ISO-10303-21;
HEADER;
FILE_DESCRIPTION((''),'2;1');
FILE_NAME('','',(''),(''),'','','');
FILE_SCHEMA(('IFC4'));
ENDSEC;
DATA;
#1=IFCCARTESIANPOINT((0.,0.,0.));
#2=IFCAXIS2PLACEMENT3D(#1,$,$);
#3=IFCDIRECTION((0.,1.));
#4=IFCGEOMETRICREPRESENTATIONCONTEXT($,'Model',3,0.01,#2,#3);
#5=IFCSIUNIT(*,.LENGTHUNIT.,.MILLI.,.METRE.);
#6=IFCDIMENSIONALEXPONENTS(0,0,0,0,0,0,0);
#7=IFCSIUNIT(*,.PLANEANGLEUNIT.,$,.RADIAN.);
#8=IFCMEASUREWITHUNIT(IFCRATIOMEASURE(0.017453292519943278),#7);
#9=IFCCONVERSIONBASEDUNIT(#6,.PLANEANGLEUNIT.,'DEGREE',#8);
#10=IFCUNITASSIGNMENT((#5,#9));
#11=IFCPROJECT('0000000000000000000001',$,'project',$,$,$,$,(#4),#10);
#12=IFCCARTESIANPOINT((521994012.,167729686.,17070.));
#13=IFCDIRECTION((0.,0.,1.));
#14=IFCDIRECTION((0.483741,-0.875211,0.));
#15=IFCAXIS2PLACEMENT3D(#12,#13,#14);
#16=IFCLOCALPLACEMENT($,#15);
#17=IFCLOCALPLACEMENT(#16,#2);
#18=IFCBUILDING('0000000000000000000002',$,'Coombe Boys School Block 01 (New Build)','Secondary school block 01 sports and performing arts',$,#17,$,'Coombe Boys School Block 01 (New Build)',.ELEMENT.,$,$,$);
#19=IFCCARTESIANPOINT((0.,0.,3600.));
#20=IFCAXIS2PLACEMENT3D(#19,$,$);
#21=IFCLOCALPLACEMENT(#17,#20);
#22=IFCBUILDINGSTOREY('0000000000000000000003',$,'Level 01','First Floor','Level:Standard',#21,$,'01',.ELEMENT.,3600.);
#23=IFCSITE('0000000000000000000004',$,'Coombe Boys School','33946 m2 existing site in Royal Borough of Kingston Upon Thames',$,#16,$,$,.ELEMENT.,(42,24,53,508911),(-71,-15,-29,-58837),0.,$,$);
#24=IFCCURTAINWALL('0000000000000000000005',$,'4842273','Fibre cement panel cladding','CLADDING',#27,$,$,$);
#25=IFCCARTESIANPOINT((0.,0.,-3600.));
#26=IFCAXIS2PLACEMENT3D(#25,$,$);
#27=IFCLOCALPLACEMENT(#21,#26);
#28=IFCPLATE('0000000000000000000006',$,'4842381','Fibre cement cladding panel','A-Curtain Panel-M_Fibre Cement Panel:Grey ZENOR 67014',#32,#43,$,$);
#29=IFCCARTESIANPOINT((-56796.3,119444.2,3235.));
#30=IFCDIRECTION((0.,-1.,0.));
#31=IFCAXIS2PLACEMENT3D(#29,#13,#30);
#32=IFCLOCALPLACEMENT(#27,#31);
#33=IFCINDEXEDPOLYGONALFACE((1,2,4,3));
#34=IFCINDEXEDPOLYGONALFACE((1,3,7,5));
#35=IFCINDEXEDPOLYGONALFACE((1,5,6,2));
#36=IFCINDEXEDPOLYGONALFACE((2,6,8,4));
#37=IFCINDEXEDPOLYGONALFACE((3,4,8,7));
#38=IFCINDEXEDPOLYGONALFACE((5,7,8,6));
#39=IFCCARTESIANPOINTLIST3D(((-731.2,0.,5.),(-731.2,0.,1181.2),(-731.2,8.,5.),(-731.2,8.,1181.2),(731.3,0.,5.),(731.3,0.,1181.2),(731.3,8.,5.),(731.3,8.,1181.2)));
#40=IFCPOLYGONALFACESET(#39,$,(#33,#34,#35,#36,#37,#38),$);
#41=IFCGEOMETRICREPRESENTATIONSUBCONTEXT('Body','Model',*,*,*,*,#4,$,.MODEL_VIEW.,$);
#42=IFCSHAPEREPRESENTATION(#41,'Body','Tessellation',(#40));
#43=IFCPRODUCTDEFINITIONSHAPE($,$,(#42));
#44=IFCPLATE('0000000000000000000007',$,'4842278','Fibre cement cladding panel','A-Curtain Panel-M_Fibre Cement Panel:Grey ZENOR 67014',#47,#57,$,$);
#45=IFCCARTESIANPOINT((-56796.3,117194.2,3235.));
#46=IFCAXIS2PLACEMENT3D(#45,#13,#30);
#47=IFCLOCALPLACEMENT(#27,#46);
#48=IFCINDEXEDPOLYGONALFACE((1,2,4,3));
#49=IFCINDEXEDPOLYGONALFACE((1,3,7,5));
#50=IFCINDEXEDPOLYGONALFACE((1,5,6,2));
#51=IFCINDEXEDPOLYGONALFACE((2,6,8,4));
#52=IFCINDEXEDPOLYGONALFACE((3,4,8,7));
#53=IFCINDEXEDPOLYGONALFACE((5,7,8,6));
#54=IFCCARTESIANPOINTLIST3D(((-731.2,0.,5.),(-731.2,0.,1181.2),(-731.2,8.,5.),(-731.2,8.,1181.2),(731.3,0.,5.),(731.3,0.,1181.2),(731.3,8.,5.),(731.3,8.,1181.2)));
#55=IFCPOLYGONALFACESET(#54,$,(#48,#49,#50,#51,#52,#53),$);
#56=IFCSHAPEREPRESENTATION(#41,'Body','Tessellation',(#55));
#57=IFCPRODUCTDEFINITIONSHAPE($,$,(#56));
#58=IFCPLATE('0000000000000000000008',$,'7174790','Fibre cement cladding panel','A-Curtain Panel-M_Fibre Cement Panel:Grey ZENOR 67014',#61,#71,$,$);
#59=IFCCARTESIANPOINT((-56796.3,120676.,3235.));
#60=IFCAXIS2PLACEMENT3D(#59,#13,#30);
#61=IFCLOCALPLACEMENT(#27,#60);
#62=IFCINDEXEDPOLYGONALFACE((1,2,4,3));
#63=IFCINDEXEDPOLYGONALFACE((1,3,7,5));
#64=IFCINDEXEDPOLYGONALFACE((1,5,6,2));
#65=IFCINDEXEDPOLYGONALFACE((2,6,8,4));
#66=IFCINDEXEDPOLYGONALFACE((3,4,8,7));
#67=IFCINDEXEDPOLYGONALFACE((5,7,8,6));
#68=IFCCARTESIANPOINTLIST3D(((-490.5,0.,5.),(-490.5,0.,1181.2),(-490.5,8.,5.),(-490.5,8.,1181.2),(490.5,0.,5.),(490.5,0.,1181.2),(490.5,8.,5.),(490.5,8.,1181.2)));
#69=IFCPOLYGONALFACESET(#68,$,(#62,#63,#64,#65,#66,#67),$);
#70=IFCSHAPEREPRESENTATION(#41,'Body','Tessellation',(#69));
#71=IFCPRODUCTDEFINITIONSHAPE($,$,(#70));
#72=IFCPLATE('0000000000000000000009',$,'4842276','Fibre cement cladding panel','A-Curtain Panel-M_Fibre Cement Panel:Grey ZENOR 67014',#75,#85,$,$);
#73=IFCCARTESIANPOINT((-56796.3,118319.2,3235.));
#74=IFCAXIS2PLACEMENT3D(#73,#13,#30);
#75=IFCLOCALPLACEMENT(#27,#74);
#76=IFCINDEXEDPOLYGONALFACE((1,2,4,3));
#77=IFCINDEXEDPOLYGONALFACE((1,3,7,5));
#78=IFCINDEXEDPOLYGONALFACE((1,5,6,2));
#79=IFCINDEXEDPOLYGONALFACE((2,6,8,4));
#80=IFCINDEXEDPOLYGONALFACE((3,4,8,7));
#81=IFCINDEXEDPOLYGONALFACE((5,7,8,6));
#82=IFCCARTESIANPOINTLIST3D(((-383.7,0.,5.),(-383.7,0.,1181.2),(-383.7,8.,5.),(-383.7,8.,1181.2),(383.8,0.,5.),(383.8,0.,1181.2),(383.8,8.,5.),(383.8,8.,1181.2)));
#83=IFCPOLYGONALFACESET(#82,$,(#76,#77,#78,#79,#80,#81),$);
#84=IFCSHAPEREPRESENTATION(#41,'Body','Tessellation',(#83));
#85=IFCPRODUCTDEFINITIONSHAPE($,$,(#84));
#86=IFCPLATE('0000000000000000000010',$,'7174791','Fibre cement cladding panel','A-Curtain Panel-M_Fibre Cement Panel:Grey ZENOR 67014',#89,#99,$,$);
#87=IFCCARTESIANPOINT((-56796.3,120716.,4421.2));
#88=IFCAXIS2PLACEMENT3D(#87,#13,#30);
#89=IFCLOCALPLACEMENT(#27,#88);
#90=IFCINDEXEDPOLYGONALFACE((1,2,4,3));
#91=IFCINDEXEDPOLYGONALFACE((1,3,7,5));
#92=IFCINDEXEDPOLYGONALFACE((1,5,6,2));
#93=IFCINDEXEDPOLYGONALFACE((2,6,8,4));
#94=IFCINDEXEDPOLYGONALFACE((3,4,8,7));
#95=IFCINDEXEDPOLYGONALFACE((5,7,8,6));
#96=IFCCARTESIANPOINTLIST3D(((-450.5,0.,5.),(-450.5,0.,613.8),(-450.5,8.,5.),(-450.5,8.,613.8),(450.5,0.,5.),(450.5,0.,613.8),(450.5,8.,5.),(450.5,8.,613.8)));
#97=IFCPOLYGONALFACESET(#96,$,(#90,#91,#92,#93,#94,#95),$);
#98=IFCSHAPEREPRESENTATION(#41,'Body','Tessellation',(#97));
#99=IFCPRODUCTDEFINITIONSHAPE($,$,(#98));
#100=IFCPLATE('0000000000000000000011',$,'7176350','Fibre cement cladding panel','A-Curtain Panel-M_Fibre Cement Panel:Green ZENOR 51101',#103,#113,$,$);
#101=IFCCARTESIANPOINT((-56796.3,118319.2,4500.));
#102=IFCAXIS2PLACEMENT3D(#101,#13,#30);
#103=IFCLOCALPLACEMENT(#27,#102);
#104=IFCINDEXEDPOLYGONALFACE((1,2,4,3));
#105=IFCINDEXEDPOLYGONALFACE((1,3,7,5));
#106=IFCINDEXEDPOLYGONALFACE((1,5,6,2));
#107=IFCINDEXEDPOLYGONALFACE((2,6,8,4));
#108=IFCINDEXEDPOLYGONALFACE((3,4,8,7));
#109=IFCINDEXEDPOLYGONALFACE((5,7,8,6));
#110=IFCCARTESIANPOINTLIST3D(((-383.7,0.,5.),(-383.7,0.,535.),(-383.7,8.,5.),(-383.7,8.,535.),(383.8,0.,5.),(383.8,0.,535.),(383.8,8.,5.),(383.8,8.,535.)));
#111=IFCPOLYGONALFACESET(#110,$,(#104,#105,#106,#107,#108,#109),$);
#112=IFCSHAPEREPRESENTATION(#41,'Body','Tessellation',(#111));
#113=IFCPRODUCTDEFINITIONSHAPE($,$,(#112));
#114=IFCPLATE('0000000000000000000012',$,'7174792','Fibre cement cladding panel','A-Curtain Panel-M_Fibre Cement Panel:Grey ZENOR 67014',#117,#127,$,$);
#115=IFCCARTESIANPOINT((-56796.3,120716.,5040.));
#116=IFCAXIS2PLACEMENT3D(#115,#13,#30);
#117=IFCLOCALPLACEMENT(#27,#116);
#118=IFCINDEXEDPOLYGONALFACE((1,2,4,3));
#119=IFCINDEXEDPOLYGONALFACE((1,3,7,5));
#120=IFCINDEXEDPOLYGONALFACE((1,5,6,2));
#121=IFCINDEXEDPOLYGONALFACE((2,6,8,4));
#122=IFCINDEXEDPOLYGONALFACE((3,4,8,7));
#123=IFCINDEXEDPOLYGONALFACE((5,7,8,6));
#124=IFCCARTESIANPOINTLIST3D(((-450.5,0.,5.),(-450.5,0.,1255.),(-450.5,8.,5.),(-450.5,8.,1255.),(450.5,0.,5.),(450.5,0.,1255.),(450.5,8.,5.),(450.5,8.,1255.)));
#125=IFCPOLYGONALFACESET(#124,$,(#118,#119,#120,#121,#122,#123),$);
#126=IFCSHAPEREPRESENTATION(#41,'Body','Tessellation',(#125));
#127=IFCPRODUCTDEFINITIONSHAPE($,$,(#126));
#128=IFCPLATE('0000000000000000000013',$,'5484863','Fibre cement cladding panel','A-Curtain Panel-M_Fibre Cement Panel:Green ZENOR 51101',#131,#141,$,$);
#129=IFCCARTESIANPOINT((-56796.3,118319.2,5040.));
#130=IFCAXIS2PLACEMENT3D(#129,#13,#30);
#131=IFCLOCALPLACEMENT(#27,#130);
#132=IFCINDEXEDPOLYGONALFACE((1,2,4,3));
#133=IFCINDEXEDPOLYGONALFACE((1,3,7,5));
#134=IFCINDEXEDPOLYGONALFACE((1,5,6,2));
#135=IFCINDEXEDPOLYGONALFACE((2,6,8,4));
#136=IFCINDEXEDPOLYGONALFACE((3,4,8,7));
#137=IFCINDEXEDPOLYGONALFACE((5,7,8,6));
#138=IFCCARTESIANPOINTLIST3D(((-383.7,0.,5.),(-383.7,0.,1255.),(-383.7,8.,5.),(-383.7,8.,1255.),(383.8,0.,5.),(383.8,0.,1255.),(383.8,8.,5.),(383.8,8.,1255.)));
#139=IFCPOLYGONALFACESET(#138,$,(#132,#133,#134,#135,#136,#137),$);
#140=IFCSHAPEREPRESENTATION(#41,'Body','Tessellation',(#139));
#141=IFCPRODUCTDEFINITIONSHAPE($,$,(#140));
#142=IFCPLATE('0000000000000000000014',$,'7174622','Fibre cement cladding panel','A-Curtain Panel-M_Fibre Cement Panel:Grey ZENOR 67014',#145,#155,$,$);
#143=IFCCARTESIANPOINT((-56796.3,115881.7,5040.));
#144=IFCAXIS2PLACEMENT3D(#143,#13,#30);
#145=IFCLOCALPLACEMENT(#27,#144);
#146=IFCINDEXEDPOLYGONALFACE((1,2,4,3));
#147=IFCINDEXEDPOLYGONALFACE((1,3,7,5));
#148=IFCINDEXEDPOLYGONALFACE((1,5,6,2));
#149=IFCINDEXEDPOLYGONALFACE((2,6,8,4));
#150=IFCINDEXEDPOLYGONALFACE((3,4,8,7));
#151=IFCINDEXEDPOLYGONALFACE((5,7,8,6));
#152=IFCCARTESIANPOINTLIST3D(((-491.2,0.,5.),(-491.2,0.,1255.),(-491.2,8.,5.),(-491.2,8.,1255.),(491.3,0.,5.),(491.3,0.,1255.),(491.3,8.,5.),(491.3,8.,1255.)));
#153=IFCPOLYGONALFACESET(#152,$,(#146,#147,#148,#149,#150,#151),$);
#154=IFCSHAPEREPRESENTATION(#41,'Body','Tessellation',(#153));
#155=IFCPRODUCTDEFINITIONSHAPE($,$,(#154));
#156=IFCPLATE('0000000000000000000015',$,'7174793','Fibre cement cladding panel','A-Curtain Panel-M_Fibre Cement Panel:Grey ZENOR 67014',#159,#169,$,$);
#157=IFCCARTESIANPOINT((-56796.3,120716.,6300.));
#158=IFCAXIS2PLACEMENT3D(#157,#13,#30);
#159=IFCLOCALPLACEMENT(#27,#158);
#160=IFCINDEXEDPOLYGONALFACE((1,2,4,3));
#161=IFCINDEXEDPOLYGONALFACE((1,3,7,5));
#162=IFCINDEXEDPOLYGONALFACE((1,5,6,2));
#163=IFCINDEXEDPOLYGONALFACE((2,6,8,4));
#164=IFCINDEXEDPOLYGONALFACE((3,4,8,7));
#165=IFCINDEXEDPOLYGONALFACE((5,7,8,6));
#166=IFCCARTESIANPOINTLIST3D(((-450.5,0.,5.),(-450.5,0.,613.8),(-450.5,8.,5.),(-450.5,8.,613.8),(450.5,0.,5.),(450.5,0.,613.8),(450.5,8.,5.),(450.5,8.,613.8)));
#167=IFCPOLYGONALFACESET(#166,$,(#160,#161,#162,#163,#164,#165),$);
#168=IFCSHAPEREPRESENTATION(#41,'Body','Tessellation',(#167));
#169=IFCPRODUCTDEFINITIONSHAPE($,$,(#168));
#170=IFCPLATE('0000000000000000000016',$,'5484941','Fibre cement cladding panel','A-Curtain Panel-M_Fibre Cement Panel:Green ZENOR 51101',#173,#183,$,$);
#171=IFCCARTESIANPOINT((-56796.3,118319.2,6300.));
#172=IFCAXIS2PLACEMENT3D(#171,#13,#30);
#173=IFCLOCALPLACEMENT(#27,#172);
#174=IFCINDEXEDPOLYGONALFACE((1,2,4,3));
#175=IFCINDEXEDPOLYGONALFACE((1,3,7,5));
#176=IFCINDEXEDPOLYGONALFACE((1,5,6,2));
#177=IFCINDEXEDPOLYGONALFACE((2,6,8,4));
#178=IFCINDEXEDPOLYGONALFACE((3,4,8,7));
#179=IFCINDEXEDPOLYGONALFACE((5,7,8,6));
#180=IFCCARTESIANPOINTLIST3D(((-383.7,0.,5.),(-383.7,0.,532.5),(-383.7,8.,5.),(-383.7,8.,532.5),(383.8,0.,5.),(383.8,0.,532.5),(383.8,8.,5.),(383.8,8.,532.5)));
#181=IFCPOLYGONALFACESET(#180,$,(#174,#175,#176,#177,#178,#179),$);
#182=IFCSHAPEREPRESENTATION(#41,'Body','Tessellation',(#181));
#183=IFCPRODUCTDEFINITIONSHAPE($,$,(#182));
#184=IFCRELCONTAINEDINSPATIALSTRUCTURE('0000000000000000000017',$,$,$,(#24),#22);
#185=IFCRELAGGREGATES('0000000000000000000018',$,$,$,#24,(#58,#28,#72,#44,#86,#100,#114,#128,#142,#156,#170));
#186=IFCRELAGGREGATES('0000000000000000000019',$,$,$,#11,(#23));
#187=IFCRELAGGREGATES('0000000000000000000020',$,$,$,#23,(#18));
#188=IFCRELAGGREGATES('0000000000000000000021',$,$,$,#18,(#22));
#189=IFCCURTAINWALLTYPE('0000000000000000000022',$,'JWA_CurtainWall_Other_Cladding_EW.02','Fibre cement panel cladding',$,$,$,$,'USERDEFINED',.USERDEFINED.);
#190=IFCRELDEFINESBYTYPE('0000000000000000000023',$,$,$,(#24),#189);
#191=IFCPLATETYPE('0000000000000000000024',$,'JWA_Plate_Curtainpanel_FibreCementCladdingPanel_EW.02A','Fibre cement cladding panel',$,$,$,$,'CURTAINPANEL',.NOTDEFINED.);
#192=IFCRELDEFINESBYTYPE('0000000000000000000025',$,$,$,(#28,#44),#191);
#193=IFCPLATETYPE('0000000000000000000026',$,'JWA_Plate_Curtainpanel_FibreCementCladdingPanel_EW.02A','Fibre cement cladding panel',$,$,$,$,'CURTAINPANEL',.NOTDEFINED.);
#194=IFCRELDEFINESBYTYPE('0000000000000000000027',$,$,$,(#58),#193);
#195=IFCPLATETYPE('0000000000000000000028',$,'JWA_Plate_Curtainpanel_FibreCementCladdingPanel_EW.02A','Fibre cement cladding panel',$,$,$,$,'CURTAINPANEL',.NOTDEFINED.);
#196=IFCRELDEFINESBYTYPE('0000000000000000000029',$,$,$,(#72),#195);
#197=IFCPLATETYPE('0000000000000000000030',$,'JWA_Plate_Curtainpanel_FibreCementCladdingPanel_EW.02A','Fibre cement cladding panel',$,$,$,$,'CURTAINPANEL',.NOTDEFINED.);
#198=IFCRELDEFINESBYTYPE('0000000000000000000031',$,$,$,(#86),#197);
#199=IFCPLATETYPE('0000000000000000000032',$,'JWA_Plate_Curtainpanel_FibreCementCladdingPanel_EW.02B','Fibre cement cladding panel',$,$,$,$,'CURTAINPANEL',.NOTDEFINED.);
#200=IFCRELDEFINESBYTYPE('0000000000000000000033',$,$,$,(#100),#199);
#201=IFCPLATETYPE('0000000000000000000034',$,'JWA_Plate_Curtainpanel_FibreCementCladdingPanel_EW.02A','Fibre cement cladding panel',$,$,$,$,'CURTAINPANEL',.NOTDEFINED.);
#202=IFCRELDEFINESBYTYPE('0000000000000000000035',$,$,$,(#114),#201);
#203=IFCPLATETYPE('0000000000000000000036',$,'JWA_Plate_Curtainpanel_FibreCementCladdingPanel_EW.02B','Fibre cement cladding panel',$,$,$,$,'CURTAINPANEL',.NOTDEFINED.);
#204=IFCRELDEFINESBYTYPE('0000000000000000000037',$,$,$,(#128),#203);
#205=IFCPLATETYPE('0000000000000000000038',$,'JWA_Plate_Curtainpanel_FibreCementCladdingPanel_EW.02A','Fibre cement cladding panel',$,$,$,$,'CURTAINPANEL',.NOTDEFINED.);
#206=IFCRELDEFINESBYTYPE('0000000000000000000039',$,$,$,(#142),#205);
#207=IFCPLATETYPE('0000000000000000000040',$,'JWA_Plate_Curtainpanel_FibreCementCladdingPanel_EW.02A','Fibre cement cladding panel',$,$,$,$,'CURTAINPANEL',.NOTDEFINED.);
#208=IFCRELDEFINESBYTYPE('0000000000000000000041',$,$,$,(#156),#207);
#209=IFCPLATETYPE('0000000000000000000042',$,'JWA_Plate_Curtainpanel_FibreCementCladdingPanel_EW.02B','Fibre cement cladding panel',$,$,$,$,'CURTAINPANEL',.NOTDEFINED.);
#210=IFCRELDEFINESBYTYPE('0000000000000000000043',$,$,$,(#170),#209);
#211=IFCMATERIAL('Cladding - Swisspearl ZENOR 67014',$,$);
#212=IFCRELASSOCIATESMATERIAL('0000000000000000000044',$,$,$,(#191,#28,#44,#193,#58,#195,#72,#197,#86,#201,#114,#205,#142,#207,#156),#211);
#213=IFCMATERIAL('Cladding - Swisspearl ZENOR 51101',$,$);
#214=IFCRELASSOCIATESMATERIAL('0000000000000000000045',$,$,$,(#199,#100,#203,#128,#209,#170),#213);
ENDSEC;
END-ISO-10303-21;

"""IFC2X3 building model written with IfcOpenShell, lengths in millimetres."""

from ifc_helpers import new_model, entity, si_unit, converted_unit, direction, frame, origin, origin_2d_with_axis, place, context, subcontext, project, spatial, rectangle, extrude, source, transform, mapped, material, type_object, type_shapes, element, aggregate, save


model = new_model("IFC2X3")

# Units and contexts
model_context = context("Model", 3, precision=0.01, world=origin(), true_north=direction((0.0, 1.0)))
body_context = subcontext(model_context, "Body", "Model", "MODEL_VIEW")
ifc_project = project(units=[si_unit("LENGTHUNIT", "METRE", prefix="MILLI"), converted_unit("PLANEANGLEUNIT", "DEGREE", entity("IfcRatioMeasure", 0.017453292519943278), si_unit("PLANEANGLEUNIT", "RADIAN"), dimensions=[0, 0, 0, 0, 0, 0, 0])], contexts=[model_context])

# Site, building, storey
site_placement = place(None, frame((521994012.0, 167729686.0, 17070.0), z_axis=(0.0, 0.0, 1.0), x_axis=(0.483741, -0.875211, 0.0)))
site = spatial("IfcSite", under=ifc_project, at=site_placement, Name="Coombe Boys School", Description="33946 m2 existing site in Royal Borough of Kingston Upon Thames", CompositionType="ELEMENT", RefLatitude=(42, 24, 53, 508911), RefLongitude=(-71, -15, -29, -58837), RefElevation=0.0)
building_placement = place(site_placement, origin())
building = spatial("IfcBuilding", under=site, at=building_placement, Name="Coombe Boys School Block 01 (New Build)", Description="Secondary school block 01 sports and performing arts", LongName="Coombe Boys School Block 01 (New Build)", CompositionType="ELEMENT")
storey_placement = place(building_placement, frame((0.0, 0.0, 3600.0)))
storey = spatial("IfcBuildingStorey", under=building, at=storey_placement, Name="Level 01", Description="First Floor", ObjectType="Level:Standard", LongName="01", CompositionType="ELEMENT", Elevation=3600.0)

# Curtain wall, plates
curtain_wall_type = type_object("IfcCurtainWallType", Name="JWA_CurtainWall_Other_Cladding_EW.02", Description="Fibre cement panel cladding", ElementType="USERDEFINED", PredefinedType="USERDEFINED")
curtain_wall_placement = place(storey_placement, frame((0.0, 0.0, -3600.0)))
curtain_wall = element("IfcCurtainWall", 1, at=curtain_wall_placement, inside=storey, type_object=curtain_wall_type, Name="4842273", Description="Fibre cement panel cladding", ObjectType="CLADDING")
ifc_material_1 = material(Name="Cladding - Swisspearl ZENOR 67014")
plate_type_1 = type_object("IfcPlateType", Name="JWA_Plate_Curtainpanel_FibreCementCladdingPanel_EW.02A", Description="Fibre cement cladding panel", ElementType="CURTAINPANEL", PredefinedType="NOTDEFINED", material=ifc_material_1)
shared_shape_1 = source(origin(), body_context, "Body", "SweptSolid", [
    extrude(rectangle(XDim=8.0, YDim=1462.5, at=origin_2d_with_axis()), frame((0.0, 4.0, 5.0), z_axis=(0.0, 0.0, 1.0), x_axis=(0.0, 1.0, 0.0)), (0.0, 0.0, 1.0), 1176.3),
])
type_shapes(plate_type_1, [shared_shape_1])
plate_1_placement = place(curtain_wall_placement, frame((-56796.3, 119444.2, 3235.0), z_axis=(0.0, 0.0, 1.0), x_axis=(0.0, -1.0, 0.0)))
plate_1 = element("IfcPlate", 2, at=plate_1_placement, type_object=plate_type_1, material=ifc_material_1, Name="4842381", Description="Fibre cement cladding panel", ObjectType="A-Curtain Panel-M_Fibre Cement Panel:Grey ZENOR 67014", context=body_context, shape_type="MappedRepresentation", body=[
    mapped(shared_shape_1, transform((0.0, 0.0, 0.0), scale=1.0)),
])
plate_2_placement = place(curtain_wall_placement, frame((-56796.3, 117194.2, 3235.0), z_axis=(0.0, 0.0, 1.0), x_axis=(0.0, -1.0, 0.0)))
plate_2 = element("IfcPlate", 3, at=plate_2_placement, type_object=plate_type_1, material=ifc_material_1, Name="4842278", Description="Fibre cement cladding panel", ObjectType="A-Curtain Panel-M_Fibre Cement Panel:Grey ZENOR 67014", context=body_context, shape_type="MappedRepresentation", body=[
    mapped(shared_shape_1, transform((0.0, 0.0, 0.0), scale=1.0)),
])
plate_type_2 = type_object("IfcPlateType", Name="JWA_Plate_Curtainpanel_FibreCementCladdingPanel_EW.02A", Description="Fibre cement cladding panel", ElementType="CURTAINPANEL", PredefinedType="NOTDEFINED", material=ifc_material_1)
shared_shape_2 = source(origin(), body_context, "Body", "SweptSolid", [
    extrude(rectangle(XDim=8.0, YDim=981.0, at=origin_2d_with_axis()), frame((0.0, 4.0, 5.0), z_axis=(0.0, 0.0, 1.0), x_axis=(0.0, 1.0, 0.0)), (0.0, 0.0, 1.0), 1176.2),
])
type_shapes(plate_type_2, [shared_shape_2])
plate_3_placement = place(curtain_wall_placement, frame((-56796.3, 120676.0, 3235.0), z_axis=(0.0, 0.0, 1.0), x_axis=(0.0, -1.0, 0.0)))
plate_3 = element("IfcPlate", 4, at=plate_3_placement, type_object=plate_type_2, material=ifc_material_1, Name="7174790", Description="Fibre cement cladding panel", ObjectType="A-Curtain Panel-M_Fibre Cement Panel:Grey ZENOR 67014", context=body_context, shape_type="MappedRepresentation", body=[
    mapped(shared_shape_2, transform((0.0, 0.0, 0.0), scale=1.0)),
])
plate_type_3 = type_object("IfcPlateType", Name="JWA_Plate_Curtainpanel_FibreCementCladdingPanel_EW.02A", Description="Fibre cement cladding panel", ElementType="CURTAINPANEL", PredefinedType="NOTDEFINED", material=ifc_material_1)
shared_shape_3 = source(origin(), body_context, "Body", "SweptSolid", [
    extrude(rectangle(XDim=8.0, YDim=767.5, at=origin_2d_with_axis()), frame((0.0, 4.0, 5.0), z_axis=(0.0, 0.0, 1.0), x_axis=(0.0, 1.0, 0.0)), (0.0, 0.0, 1.0), 1176.2),
])
type_shapes(plate_type_3, [shared_shape_3])
plate_4_placement = place(curtain_wall_placement, frame((-56796.3, 118319.2, 3235.0), z_axis=(0.0, 0.0, 1.0), x_axis=(0.0, -1.0, 0.0)))
plate_4 = element("IfcPlate", 5, at=plate_4_placement, type_object=plate_type_3, material=ifc_material_1, Name="4842276", Description="Fibre cement cladding panel", ObjectType="A-Curtain Panel-M_Fibre Cement Panel:Grey ZENOR 67014", context=body_context, shape_type="MappedRepresentation", body=[
    mapped(shared_shape_3, transform((0.0, 0.0, 0.0), scale=1.0)),
])
plate_type_4 = type_object("IfcPlateType", Name="JWA_Plate_Curtainpanel_FibreCementCladdingPanel_EW.02A", Description="Fibre cement cladding panel", ElementType="CURTAINPANEL", PredefinedType="NOTDEFINED", material=ifc_material_1)
shared_shape_4 = source(origin(), body_context, "Body", "SweptSolid", [
    extrude(rectangle(XDim=8.0, YDim=901.0, at=origin_2d_with_axis()), frame((0.0, 4.0, 5.0), z_axis=(0.0, 0.0, 1.0), x_axis=(0.0, 1.0, 0.0)), (0.0, 0.0, 1.0), 608.8),
])
type_shapes(plate_type_4, [shared_shape_4])
plate_5_placement = place(curtain_wall_placement, frame((-56796.3, 120716.0, 4421.2), z_axis=(0.0, 0.0, 1.0), x_axis=(0.0, -1.0, 0.0)))
plate_5 = element("IfcPlate", 6, at=plate_5_placement, type_object=plate_type_4, material=ifc_material_1, Name="7174791", Description="Fibre cement cladding panel", ObjectType="A-Curtain Panel-M_Fibre Cement Panel:Grey ZENOR 67014", context=body_context, shape_type="MappedRepresentation", body=[
    mapped(shared_shape_4, transform((0.0, 0.0, 0.0), scale=1.0)),
])
ifc_material_2 = material(Name="Cladding - Swisspearl ZENOR 51101")
plate_type_5 = type_object("IfcPlateType", Name="JWA_Plate_Curtainpanel_FibreCementCladdingPanel_EW.02B", Description="Fibre cement cladding panel", ElementType="CURTAINPANEL", PredefinedType="NOTDEFINED", material=ifc_material_2)
shared_shape_5 = source(origin(), body_context, "Body", "SweptSolid", [
    extrude(rectangle(XDim=8.0, YDim=767.5, at=origin_2d_with_axis()), frame((0.0, 4.0, 5.0), z_axis=(0.0, 0.0, 1.0), x_axis=(0.0, 1.0, 0.0)), (0.0, 0.0, 1.0), 530.0),
])
type_shapes(plate_type_5, [shared_shape_5])
plate_6_placement = place(curtain_wall_placement, frame((-56796.3, 118319.2, 4500.0), z_axis=(0.0, 0.0, 1.0), x_axis=(0.0, -1.0, 0.0)))
plate_6 = element("IfcPlate", 7, at=plate_6_placement, type_object=plate_type_5, material=ifc_material_2, Name="7176350", Description="Fibre cement cladding panel", ObjectType="A-Curtain Panel-M_Fibre Cement Panel:Green ZENOR 51101", context=body_context, shape_type="MappedRepresentation", body=[
    mapped(shared_shape_5, transform((0.0, 0.0, 0.0), scale=1.0)),
])
plate_type_6 = type_object("IfcPlateType", Name="JWA_Plate_Curtainpanel_FibreCementCladdingPanel_EW.02A", Description="Fibre cement cladding panel", ElementType="CURTAINPANEL", PredefinedType="NOTDEFINED", material=ifc_material_1)
shared_shape_6 = source(origin(), body_context, "Body", "SweptSolid", [
    extrude(rectangle(XDim=8.0, YDim=901.0, at=origin_2d_with_axis()), frame((0.0, 4.0, 5.0), z_axis=(0.0, 0.0, 1.0), x_axis=(0.0, 1.0, 0.0)), (0.0, 0.0, 1.0), 1250.0),
])
type_shapes(plate_type_6, [shared_shape_6])
plate_7_placement = place(curtain_wall_placement, frame((-56796.3, 120716.0, 5040.0), z_axis=(0.0, 0.0, 1.0), x_axis=(0.0, -1.0, 0.0)))
plate_7 = element("IfcPlate", 8, at=plate_7_placement, type_object=plate_type_6, material=ifc_material_1, Name="7174792", Description="Fibre cement cladding panel", ObjectType="A-Curtain Panel-M_Fibre Cement Panel:Grey ZENOR 67014", context=body_context, shape_type="MappedRepresentation", body=[
    mapped(shared_shape_6, transform((0.0, 0.0, 0.0), scale=1.0)),
])
plate_type_7 = type_object("IfcPlateType", Name="JWA_Plate_Curtainpanel_FibreCementCladdingPanel_EW.02B", Description="Fibre cement cladding panel", ElementType="CURTAINPANEL", PredefinedType="NOTDEFINED", material=ifc_material_2)
shared_shape_7 = source(origin(), body_context, "Body", "SweptSolid", [
    extrude(rectangle(XDim=8.0, YDim=767.5, at=origin_2d_with_axis()), frame((0.0, 4.0, 5.0), z_axis=(0.0, 0.0, 1.0), x_axis=(0.0, 1.0, 0.0)), (0.0, 0.0, 1.0), 1250.0),
])
type_shapes(plate_type_7, [shared_shape_7])
plate_8_placement = place(curtain_wall_placement, frame((-56796.3, 118319.2, 5040.0), z_axis=(0.0, 0.0, 1.0), x_axis=(0.0, -1.0, 0.0)))
plate_8 = element("IfcPlate", 9, at=plate_8_placement, type_object=plate_type_7, material=ifc_material_2, Name="5484863", Description="Fibre cement cladding panel", ObjectType="A-Curtain Panel-M_Fibre Cement Panel:Green ZENOR 51101", context=body_context, shape_type="MappedRepresentation", body=[
    mapped(shared_shape_7, transform((0.0, 0.0, 0.0), scale=1.0)),
])
plate_type_8 = type_object("IfcPlateType", Name="JWA_Plate_Curtainpanel_FibreCementCladdingPanel_EW.02A", Description="Fibre cement cladding panel", ElementType="CURTAINPANEL", PredefinedType="NOTDEFINED", material=ifc_material_1)
shared_shape_8 = source(origin(), body_context, "Body", "SweptSolid", [
    extrude(rectangle(XDim=8.0, YDim=982.5, at=origin_2d_with_axis()), frame((0.0, 4.0, 5.0), z_axis=(0.0, 0.0, 1.0), x_axis=(0.0, 1.0, 0.0)), (0.0, 0.0, 1.0), 1250.0),
])
type_shapes(plate_type_8, [shared_shape_8])
plate_9_placement = place(curtain_wall_placement, frame((-56796.3, 115881.7, 5040.0), z_axis=(0.0, 0.0, 1.0), x_axis=(0.0, -1.0, 0.0)))
plate_9 = element("IfcPlate", 10, at=plate_9_placement, type_object=plate_type_8, material=ifc_material_1, Name="7174622", Description="Fibre cement cladding panel", ObjectType="A-Curtain Panel-M_Fibre Cement Panel:Grey ZENOR 67014", context=body_context, shape_type="MappedRepresentation", body=[
    mapped(shared_shape_8, transform((0.0, 0.0, 0.0), scale=1.0)),
])
plate_type_9 = type_object("IfcPlateType", Name="JWA_Plate_Curtainpanel_FibreCementCladdingPanel_EW.02A", Description="Fibre cement cladding panel", ElementType="CURTAINPANEL", PredefinedType="NOTDEFINED", material=ifc_material_1)
shared_shape_9 = source(origin(), body_context, "Body", "SweptSolid", [
    extrude(rectangle(XDim=8.0, YDim=901.0, at=origin_2d_with_axis()), frame((0.0, 4.0, 5.0), z_axis=(0.0, 0.0, 1.0), x_axis=(0.0, 1.0, 0.0)), (0.0, 0.0, 1.0), 608.8),
])
type_shapes(plate_type_9, [shared_shape_9])
plate_10_placement = place(curtain_wall_placement, frame((-56796.3, 120716.0, 6300.0), z_axis=(0.0, 0.0, 1.0), x_axis=(0.0, -1.0, 0.0)))
plate_10 = element("IfcPlate", 11, at=plate_10_placement, type_object=plate_type_9, material=ifc_material_1, Name="7174793", Description="Fibre cement cladding panel", ObjectType="A-Curtain Panel-M_Fibre Cement Panel:Grey ZENOR 67014", context=body_context, shape_type="MappedRepresentation", body=[
    mapped(shared_shape_9, transform((0.0, 0.0, 0.0), scale=1.0)),
])
plate_type_10 = type_object("IfcPlateType", Name="JWA_Plate_Curtainpanel_FibreCementCladdingPanel_EW.02B", Description="Fibre cement cladding panel", ElementType="CURTAINPANEL", PredefinedType="NOTDEFINED", material=ifc_material_2)
shared_shape_10 = source(origin(), body_context, "Body", "SweptSolid", [
    extrude(rectangle(XDim=8.0, YDim=767.5, at=origin_2d_with_axis()), frame((0.0, 4.0, 5.0), z_axis=(0.0, 0.0, 1.0), x_axis=(0.0, 1.0, 0.0)), (0.0, 0.0, 1.0), 527.5),
])
type_shapes(plate_type_10, [shared_shape_10])
plate_11_placement = place(curtain_wall_placement, frame((-56796.3, 118319.2, 6300.0), z_axis=(0.0, 0.0, 1.0), x_axis=(0.0, -1.0, 0.0)))
plate_11 = element("IfcPlate", 12, at=plate_11_placement, type_object=plate_type_10, material=ifc_material_2, Name="5484941", Description="Fibre cement cladding panel", ObjectType="A-Curtain Panel-M_Fibre Cement Panel:Green ZENOR 51101", context=body_context, shape_type="MappedRepresentation", body=[
    mapped(shared_shape_10, transform((0.0, 0.0, 0.0), scale=1.0)),
])
aggregate(curtain_wall, [plate_3, plate_1, plate_4, plate_2, plate_5, plate_6, plate_7, plate_8, plate_9, plate_10, plate_11])

save(model, "model.ifc")
